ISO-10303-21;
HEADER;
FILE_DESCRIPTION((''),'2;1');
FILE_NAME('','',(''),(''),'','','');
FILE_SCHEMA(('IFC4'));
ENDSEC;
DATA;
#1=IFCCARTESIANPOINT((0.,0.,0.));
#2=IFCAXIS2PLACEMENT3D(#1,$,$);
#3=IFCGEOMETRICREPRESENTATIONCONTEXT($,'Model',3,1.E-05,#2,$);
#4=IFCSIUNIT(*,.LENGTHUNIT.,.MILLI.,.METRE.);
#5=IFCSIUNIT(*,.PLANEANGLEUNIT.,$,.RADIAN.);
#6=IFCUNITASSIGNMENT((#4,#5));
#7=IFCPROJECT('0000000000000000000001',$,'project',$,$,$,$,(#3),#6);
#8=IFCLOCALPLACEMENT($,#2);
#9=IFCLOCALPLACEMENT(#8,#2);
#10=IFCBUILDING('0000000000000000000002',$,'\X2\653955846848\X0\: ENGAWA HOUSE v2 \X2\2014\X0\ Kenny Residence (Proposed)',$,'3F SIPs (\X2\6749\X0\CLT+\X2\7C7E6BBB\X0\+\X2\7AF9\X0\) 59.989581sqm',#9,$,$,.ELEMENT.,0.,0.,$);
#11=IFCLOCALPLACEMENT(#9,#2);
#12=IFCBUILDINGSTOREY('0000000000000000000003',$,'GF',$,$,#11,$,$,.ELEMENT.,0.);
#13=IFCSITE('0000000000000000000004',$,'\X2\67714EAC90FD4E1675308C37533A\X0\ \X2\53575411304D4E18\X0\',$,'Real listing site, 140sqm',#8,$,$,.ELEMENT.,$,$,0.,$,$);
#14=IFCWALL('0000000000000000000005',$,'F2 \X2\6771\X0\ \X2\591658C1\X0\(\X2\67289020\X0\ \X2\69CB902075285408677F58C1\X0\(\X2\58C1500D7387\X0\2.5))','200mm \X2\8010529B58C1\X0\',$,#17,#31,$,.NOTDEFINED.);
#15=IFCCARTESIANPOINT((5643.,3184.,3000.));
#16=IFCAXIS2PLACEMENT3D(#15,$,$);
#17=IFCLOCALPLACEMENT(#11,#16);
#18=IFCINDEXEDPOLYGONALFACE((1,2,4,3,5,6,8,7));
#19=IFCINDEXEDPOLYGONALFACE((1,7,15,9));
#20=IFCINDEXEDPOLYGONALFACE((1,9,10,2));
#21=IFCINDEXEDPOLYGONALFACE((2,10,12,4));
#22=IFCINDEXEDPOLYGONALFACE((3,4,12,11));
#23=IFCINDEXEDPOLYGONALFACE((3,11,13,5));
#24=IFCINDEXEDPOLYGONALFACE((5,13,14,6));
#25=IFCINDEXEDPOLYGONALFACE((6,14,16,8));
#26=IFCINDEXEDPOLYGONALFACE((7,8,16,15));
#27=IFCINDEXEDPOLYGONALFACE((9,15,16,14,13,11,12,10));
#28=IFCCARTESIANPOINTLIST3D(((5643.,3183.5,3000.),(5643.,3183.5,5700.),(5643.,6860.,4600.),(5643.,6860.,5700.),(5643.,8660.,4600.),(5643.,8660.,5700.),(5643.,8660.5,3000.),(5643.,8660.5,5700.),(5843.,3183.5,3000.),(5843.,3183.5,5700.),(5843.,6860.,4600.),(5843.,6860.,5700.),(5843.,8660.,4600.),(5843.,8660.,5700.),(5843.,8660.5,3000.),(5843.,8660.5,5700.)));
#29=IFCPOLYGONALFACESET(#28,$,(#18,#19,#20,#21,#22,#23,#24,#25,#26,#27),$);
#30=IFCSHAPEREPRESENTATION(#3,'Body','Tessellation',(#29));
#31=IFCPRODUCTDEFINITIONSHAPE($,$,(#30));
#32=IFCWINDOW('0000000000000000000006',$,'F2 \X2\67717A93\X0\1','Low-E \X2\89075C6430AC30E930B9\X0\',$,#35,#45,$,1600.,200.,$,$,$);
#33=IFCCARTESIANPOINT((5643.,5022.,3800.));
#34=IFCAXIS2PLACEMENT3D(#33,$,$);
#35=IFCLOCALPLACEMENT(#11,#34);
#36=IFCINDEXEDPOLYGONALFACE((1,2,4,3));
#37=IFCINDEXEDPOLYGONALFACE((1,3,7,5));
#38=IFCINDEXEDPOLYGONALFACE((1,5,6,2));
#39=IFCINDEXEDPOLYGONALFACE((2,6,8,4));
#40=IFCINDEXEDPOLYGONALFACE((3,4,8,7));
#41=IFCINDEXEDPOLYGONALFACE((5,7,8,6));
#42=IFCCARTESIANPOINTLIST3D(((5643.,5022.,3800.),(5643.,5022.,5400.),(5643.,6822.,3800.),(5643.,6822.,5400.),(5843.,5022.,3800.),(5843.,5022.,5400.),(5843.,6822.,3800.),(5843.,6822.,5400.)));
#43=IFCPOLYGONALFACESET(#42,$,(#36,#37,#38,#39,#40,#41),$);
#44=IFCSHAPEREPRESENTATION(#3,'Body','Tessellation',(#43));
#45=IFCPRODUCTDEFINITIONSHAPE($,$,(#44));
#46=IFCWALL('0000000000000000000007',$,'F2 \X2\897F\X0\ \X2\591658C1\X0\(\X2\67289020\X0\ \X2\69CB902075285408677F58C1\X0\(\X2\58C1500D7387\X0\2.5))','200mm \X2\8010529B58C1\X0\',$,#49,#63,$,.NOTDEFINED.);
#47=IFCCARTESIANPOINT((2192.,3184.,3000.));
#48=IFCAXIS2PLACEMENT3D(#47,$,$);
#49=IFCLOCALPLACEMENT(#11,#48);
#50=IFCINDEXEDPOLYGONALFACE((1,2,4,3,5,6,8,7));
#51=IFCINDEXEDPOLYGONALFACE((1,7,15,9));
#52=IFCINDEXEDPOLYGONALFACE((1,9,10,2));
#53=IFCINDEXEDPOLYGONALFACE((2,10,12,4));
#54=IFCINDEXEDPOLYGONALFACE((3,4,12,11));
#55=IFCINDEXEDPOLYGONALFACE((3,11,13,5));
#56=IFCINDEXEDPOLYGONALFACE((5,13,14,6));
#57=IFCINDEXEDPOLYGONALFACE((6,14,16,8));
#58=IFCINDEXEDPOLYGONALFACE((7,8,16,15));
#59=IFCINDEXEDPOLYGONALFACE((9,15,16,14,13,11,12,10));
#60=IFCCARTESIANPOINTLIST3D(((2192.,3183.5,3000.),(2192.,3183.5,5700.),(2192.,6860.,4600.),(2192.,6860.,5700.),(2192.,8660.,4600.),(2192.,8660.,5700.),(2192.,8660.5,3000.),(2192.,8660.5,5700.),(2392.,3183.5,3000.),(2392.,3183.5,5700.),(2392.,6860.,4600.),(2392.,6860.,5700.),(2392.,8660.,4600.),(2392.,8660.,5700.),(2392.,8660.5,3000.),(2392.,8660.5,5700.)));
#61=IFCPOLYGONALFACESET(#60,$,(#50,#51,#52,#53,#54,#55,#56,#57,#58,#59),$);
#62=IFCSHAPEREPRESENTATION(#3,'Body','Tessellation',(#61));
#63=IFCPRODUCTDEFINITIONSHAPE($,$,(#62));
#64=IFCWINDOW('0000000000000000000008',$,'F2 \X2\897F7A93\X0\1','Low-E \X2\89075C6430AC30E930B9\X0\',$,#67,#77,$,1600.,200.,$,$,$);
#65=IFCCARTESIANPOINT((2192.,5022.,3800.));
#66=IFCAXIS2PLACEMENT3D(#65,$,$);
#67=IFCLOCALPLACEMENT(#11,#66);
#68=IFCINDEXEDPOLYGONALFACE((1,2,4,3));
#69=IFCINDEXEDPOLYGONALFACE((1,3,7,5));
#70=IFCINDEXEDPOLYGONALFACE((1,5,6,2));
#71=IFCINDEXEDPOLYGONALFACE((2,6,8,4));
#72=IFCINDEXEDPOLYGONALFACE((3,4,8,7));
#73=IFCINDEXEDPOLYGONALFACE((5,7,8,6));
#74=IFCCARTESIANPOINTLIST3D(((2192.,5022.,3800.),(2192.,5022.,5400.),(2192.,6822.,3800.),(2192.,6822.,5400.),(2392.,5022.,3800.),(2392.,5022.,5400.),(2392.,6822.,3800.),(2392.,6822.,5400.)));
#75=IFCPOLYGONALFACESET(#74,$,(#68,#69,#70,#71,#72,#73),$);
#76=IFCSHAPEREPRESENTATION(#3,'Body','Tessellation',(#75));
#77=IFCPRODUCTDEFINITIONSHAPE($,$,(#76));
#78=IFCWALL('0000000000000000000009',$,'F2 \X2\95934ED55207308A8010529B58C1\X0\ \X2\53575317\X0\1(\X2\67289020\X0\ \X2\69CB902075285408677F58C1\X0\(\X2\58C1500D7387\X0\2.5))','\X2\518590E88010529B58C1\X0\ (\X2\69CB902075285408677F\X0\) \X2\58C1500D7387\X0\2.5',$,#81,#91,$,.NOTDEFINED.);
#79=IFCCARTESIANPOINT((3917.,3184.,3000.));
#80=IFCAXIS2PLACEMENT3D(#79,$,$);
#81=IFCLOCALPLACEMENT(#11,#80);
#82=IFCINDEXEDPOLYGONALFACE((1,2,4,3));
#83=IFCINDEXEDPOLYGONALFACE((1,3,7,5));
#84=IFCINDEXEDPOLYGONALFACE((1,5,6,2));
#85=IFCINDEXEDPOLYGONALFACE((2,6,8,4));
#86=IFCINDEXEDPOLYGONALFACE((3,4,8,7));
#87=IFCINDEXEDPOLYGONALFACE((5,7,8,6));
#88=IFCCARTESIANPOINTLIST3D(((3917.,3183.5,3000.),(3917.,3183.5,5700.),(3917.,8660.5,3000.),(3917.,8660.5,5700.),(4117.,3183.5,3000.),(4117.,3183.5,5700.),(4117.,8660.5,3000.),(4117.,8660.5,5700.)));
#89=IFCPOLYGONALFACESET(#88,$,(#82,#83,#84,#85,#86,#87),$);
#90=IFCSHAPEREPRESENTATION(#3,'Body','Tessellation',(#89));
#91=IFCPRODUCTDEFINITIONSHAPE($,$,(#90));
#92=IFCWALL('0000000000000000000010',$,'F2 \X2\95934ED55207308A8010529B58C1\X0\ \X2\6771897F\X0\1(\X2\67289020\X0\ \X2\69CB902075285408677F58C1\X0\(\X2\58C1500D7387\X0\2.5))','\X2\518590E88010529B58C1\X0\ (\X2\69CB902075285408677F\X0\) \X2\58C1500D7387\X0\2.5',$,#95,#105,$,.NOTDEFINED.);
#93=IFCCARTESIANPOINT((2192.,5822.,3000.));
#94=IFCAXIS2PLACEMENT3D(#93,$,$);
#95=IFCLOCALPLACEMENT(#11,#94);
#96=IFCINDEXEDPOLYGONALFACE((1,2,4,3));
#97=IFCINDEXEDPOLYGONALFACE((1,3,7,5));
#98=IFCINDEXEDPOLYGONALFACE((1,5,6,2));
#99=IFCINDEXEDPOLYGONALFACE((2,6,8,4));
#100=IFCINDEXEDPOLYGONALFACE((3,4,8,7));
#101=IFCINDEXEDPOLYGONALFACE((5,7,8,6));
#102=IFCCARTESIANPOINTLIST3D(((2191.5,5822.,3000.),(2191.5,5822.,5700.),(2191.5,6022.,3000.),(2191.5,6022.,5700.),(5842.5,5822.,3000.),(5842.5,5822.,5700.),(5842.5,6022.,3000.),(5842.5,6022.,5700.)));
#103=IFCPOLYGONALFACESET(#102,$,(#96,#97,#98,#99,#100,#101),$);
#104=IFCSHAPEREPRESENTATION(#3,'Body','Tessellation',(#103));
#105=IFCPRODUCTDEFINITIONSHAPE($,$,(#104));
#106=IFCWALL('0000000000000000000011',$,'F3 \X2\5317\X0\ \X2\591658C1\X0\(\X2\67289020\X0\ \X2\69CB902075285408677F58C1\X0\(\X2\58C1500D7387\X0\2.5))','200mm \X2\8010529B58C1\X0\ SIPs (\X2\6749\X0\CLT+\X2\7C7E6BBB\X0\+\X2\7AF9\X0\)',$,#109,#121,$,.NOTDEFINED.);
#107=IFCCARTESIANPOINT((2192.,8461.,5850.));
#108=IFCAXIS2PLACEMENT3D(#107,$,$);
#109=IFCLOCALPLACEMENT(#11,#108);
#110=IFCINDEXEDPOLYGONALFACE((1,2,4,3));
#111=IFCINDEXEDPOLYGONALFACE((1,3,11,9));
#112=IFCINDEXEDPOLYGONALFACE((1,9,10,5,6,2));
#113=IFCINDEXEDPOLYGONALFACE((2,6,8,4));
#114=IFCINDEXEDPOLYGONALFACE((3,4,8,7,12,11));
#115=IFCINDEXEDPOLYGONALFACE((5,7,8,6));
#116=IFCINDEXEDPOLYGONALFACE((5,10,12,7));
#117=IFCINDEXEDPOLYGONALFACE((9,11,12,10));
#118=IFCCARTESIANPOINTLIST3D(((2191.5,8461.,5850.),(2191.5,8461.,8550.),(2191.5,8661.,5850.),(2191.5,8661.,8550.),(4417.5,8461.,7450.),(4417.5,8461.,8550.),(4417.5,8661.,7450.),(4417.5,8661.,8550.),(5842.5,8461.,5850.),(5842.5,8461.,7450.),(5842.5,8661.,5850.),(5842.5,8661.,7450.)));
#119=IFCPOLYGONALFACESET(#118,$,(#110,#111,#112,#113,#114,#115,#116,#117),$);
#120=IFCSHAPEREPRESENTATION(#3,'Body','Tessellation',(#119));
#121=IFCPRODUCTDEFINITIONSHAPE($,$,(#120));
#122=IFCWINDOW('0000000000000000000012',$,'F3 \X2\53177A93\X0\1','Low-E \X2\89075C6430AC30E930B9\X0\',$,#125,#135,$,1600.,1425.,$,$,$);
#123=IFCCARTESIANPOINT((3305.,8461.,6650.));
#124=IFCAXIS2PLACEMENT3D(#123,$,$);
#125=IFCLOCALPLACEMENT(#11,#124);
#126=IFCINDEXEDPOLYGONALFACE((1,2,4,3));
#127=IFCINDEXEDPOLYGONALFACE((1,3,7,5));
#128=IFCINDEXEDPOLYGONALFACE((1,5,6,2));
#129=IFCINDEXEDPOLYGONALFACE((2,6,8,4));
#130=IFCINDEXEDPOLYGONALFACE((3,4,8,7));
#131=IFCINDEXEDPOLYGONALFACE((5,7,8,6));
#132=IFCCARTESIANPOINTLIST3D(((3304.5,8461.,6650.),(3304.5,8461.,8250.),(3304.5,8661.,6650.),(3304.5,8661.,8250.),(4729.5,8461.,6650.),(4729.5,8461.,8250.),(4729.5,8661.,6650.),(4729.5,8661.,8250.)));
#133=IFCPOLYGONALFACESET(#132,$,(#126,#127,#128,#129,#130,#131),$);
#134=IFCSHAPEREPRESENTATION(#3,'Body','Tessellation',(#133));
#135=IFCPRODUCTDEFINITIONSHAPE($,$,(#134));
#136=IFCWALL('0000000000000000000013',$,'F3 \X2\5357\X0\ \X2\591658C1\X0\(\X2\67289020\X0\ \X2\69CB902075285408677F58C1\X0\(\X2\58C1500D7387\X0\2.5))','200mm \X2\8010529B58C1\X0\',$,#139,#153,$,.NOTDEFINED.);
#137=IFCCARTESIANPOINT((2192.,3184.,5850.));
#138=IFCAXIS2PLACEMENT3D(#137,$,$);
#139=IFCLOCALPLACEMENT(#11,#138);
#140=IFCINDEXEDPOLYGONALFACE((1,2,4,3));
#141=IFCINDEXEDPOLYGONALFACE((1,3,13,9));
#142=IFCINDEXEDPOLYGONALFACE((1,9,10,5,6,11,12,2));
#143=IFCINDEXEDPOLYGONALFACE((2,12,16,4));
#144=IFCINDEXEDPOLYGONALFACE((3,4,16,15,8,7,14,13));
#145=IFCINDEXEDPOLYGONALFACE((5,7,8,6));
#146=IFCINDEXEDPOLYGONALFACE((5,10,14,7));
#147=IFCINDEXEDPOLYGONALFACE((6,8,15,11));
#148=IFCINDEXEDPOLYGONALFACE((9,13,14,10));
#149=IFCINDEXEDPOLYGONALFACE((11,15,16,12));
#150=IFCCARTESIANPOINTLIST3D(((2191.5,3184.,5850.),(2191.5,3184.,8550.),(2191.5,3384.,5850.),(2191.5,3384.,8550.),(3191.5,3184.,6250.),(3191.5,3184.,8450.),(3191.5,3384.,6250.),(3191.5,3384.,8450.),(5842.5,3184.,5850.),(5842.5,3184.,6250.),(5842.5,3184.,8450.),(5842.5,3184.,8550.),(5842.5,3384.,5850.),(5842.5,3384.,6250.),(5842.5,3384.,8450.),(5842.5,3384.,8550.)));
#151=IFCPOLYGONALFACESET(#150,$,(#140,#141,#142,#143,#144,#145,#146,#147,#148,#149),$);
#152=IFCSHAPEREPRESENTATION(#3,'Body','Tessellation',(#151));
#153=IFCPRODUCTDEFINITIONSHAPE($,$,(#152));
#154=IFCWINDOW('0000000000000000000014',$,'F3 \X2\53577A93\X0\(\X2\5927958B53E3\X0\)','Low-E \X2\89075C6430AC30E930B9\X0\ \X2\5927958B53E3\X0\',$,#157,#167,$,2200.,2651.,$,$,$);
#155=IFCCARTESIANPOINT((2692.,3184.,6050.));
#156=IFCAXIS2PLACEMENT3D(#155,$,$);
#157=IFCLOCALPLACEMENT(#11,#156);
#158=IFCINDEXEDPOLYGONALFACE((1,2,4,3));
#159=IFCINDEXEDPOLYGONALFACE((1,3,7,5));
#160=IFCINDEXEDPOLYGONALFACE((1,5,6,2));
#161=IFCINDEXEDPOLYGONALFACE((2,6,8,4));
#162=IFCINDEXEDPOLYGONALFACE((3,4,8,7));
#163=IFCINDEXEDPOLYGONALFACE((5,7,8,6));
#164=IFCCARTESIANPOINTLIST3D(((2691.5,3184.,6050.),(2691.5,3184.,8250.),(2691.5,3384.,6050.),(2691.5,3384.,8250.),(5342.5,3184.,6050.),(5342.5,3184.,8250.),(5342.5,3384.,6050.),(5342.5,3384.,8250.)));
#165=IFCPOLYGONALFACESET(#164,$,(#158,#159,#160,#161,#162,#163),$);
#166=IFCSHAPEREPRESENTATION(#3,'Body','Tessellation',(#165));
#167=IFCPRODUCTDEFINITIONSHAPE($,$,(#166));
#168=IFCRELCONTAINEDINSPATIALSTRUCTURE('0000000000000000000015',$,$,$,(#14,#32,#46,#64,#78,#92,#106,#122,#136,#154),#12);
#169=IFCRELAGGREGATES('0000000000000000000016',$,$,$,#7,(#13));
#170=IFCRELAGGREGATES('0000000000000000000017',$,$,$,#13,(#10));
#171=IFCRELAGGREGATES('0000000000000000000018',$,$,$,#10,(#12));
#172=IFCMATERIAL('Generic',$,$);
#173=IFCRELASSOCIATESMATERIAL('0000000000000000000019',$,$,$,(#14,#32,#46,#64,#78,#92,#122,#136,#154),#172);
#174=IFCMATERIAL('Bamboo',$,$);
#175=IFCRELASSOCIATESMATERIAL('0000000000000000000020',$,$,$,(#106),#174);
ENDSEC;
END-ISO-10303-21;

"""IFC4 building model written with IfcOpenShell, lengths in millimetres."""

from ifc_helpers import new_model, si_unit, frame, frame_2d, origin, place, context, project, spatial, rectangle, extrude, material, element, fill, save


model = new_model("IFC4")

# Units and contexts
model_context = context("Model", 3, precision=1e-05, world=origin())
ifc_project = project(units=[si_unit("LENGTHUNIT", "METRE", prefix="MILLI"), si_unit("PLANEANGLEUNIT", "RADIAN")], contexts=[model_context])

# Site, building, storey
site_placement = place(None, origin())
site = spatial("IfcSite", under=ifc_project, at=site_placement, Name="東京都世田谷区 南向き丘", ObjectType="Real listing site, 140sqm", CompositionType="ELEMENT", RefElevation=0.0)
building_placement = place(site_placement, origin())
building = spatial("IfcBuilding", under=site, at=building_placement, Name="改善案: ENGAWA HOUSE v2 — Kenny Residence (Proposed)", ObjectType="3F SIPs (杉CLT+籾殻+竹) 59.989581sqm", CompositionType="ELEMENT", ElevationOfRefHeight=0.0, ElevationOfTerrain=0.0)
storey_placement = place(building_placement, origin())
storey = spatial("IfcBuildingStorey", under=building, at=storey_placement, Name="GF", CompositionType="ELEMENT", Elevation=0.0)

# Shared definitions
ifc_material_1 = material(Name="Generic")

# Walls, openings, windows
wall_1_placement = place(storey_placement, frame((5643.0, 3184.0, 3000.0)))
wall_1 = element("IfcWall", 1, at=wall_1_placement, inside=storey, material=ifc_material_1, Name="F2 東 外壁(木造 構造用合板壁(壁倍率2.5))", Description="200mm 耐力壁", PredefinedType="NOTDEFINED", context=model_context, shape_type="SweptSolid", body=[
    extrude(rectangle(XDim=200.0, YDim=5477.0, at=frame_2d((100.0, 2738.0))), frame((5643.0, 3184.0, 3000.0)), (0.0, 0.0, 1.0), 2700.0),
])
opening_1_placement = place(storey_placement, frame((5643.0, 5022.0, 3800.0)))
opening_1 = element("IfcOpeningElement", 2, at=opening_1_placement, cuts=wall_1, PredefinedType="NOTDEFINED", context=model_context, shape_type="SweptSolid", body=[
    extrude(rectangle(XDim=200.0, YDim=1800.0, at=frame_2d((100.0, 900.0))), frame((5643.0, 5022.0, 3800.0)), (0.0, 0.0, 1.0), 1600.0),
])
window_1_placement = place(storey_placement, frame((5643.0, 5022.0, 3800.0)))
window_1 = element("IfcWindow", 3, at=window_1_placement, inside=storey, material=ifc_material_1, Name="F2 東窓1", Description="Low-E 複層ガラス", OverallHeight=1600.0, OverallWidth=200.0, context=model_context, shape_type="SweptSolid", body=[
    extrude(rectangle(XDim=200.0, YDim=1800.0, at=frame_2d((100.0, 900.0))), frame((5643.0, 5022.0, 3800.0)), (0.0, 0.0, 1.0), 1600.0),
])
fill(opening_1, window_1)
wall_2_placement = place(storey_placement, frame((2192.0, 3184.0, 3000.0)))
wall_2 = element("IfcWall", 4, at=wall_2_placement, inside=storey, material=ifc_material_1, Name="F2 西 外壁(木造 構造用合板壁(壁倍率2.5))", Description="200mm 耐力壁", PredefinedType="NOTDEFINED", context=model_context, shape_type="SweptSolid", body=[
    extrude(rectangle(XDim=200.0, YDim=5477.0, at=frame_2d((100.0, 2738.0))), frame((2192.0, 3184.0, 3000.0)), (0.0, 0.0, 1.0), 2700.0),
])
opening_2_placement = place(storey_placement, frame((2192.0, 5022.0, 3800.0)))
opening_2 = element("IfcOpeningElement", 5, at=opening_2_placement, cuts=wall_2, PredefinedType="NOTDEFINED", context=model_context, shape_type="SweptSolid", body=[
    extrude(rectangle(XDim=200.0, YDim=1800.0, at=frame_2d((100.0, 900.0))), frame((2192.0, 5022.0, 3800.0)), (0.0, 0.0, 1.0), 1600.0),
])
window_2_placement = place(storey_placement, frame((2192.0, 5022.0, 3800.0)))
window_2 = element("IfcWindow", 6, at=window_2_placement, inside=storey, material=ifc_material_1, Name="F2 西窓1", Description="Low-E 複層ガラス", OverallHeight=1600.0, OverallWidth=200.0, context=model_context, shape_type="SweptSolid", body=[
    extrude(rectangle(XDim=200.0, YDim=1800.0, at=frame_2d((100.0, 900.0))), frame((2192.0, 5022.0, 3800.0)), (0.0, 0.0, 1.0), 1600.0),
])
fill(opening_2, window_2)

# Walls
wall_3_placement = place(storey_placement, frame((3917.0, 3184.0, 3000.0)))
element("IfcWall", 7, at=wall_3_placement, inside=storey, material=ifc_material_1, Name="F2 間仕切り耐力壁 南北1(木造 構造用合板壁(壁倍率2.5))", Description="内部耐力壁 (構造用合板) 壁倍率2.5", PredefinedType="NOTDEFINED", context=model_context, shape_type="SweptSolid", body=[
    extrude(rectangle(XDim=200.0, YDim=5477.0, at=frame_2d((100.0, 2738.0))), frame((3917.0, 3184.0, 3000.0)), (0.0, 0.0, 1.0), 2700.0),
])
wall_4_placement = place(storey_placement, frame((2192.0, 5822.0, 3000.0)))
element("IfcWall", 8, at=wall_4_placement, inside=storey, material=ifc_material_1, Name="F2 間仕切り耐力壁 東西1(木造 構造用合板壁(壁倍率2.5))", Description="内部耐力壁 (構造用合板) 壁倍率2.5", PredefinedType="NOTDEFINED", context=model_context, shape_type="SweptSolid", body=[
    extrude(rectangle(XDim=3651.0, YDim=200.0, at=frame_2d((1825.0, 100.0))), frame((2192.0, 5822.0, 3000.0)), (0.0, 0.0, 1.0), 2700.0),
])

# Walls, openings, windows
ifc_material_2 = material(Name="Bamboo")
wall_5_placement = place(storey_placement, frame((2192.0, 8461.0, 5850.0)))
wall_5 = element("IfcWall", 9, at=wall_5_placement, inside=storey, material=ifc_material_2, Name="F3 北 外壁(木造 構造用合板壁(壁倍率2.5))", Description="200mm 耐力壁 SIPs (杉CLT+籾殻+竹)", PredefinedType="NOTDEFINED", context=model_context, shape_type="SweptSolid", body=[
    extrude(rectangle(XDim=3651.0, YDim=200.0, at=frame_2d((1825.0, 100.0))), frame((2192.0, 8461.0, 5850.0)), (0.0, 0.0, 1.0), 2700.0),
])
opening_3_placement = place(storey_placement, frame((3305.0, 8461.0, 6650.0)))
opening_3 = element("IfcOpeningElement", 10, at=opening_3_placement, cuts=wall_5, PredefinedType="NOTDEFINED", context=model_context, shape_type="SweptSolid", body=[
    extrude(rectangle(XDim=1425.0, YDim=200.0, at=frame_2d((712.0, 100.0))), frame((3305.0, 8461.0, 6650.0)), (0.0, 0.0, 1.0), 1600.0),
])
window_3_placement = place(storey_placement, frame((3305.0, 8461.0, 6650.0)))
window_3 = element("IfcWindow", 11, at=window_3_placement, inside=storey, material=ifc_material_1, Name="F3 北窓1", Description="Low-E 複層ガラス", OverallHeight=1600.0, OverallWidth=1425.0, context=model_context, shape_type="SweptSolid", body=[
    extrude(rectangle(XDim=1425.0, YDim=200.0, at=frame_2d((712.0, 100.0))), frame((3305.0, 8461.0, 6650.0)), (0.0, 0.0, 1.0), 1600.0),
])
fill(opening_3, window_3)
wall_6_placement = place(storey_placement, frame((2192.0, 3184.0, 5850.0)))
wall_6 = element("IfcWall", 12, at=wall_6_placement, inside=storey, material=ifc_material_1, Name="F3 南 外壁(木造 構造用合板壁(壁倍率2.5))", Description="200mm 耐力壁", PredefinedType="NOTDEFINED", context=model_context, shape_type="SweptSolid", body=[
    extrude(rectangle(XDim=3651.0, YDim=200.0, at=frame_2d((1825.0, 100.0))), frame((2192.0, 3184.0, 5850.0)), (0.0, 0.0, 1.0), 2700.0),
])
opening_4_placement = place(storey_placement, frame((2692.0, 3184.0, 6050.0)))
opening_4 = element("IfcOpeningElement", 13, at=opening_4_placement, cuts=wall_6, PredefinedType="NOTDEFINED", context=model_context, shape_type="SweptSolid", body=[
    extrude(rectangle(XDim=2651.0, YDim=200.0, at=frame_2d((1325.0, 100.0))), frame((2692.0, 3184.0, 6050.0)), (0.0, 0.0, 1.0), 2200.0),
])
window_4_placement = place(storey_placement, frame((2692.0, 3184.0, 6050.0)))
window_4 = element("IfcWindow", 14, at=window_4_placement, inside=storey, material=ifc_material_1, Name="F3 南窓(大開口)", Description="Low-E 複層ガラス 大開口", OverallHeight=2200.0, OverallWidth=2651.0, context=model_context, shape_type="SweptSolid", body=[
    extrude(rectangle(XDim=2651.0, YDim=200.0, at=frame_2d((1325.0, 100.0))), frame((2692.0, 3184.0, 6050.0)), (0.0, 0.0, 1.0), 2200.0),
])
fill(opening_4, window_4)

save(model, "model.ifc")
